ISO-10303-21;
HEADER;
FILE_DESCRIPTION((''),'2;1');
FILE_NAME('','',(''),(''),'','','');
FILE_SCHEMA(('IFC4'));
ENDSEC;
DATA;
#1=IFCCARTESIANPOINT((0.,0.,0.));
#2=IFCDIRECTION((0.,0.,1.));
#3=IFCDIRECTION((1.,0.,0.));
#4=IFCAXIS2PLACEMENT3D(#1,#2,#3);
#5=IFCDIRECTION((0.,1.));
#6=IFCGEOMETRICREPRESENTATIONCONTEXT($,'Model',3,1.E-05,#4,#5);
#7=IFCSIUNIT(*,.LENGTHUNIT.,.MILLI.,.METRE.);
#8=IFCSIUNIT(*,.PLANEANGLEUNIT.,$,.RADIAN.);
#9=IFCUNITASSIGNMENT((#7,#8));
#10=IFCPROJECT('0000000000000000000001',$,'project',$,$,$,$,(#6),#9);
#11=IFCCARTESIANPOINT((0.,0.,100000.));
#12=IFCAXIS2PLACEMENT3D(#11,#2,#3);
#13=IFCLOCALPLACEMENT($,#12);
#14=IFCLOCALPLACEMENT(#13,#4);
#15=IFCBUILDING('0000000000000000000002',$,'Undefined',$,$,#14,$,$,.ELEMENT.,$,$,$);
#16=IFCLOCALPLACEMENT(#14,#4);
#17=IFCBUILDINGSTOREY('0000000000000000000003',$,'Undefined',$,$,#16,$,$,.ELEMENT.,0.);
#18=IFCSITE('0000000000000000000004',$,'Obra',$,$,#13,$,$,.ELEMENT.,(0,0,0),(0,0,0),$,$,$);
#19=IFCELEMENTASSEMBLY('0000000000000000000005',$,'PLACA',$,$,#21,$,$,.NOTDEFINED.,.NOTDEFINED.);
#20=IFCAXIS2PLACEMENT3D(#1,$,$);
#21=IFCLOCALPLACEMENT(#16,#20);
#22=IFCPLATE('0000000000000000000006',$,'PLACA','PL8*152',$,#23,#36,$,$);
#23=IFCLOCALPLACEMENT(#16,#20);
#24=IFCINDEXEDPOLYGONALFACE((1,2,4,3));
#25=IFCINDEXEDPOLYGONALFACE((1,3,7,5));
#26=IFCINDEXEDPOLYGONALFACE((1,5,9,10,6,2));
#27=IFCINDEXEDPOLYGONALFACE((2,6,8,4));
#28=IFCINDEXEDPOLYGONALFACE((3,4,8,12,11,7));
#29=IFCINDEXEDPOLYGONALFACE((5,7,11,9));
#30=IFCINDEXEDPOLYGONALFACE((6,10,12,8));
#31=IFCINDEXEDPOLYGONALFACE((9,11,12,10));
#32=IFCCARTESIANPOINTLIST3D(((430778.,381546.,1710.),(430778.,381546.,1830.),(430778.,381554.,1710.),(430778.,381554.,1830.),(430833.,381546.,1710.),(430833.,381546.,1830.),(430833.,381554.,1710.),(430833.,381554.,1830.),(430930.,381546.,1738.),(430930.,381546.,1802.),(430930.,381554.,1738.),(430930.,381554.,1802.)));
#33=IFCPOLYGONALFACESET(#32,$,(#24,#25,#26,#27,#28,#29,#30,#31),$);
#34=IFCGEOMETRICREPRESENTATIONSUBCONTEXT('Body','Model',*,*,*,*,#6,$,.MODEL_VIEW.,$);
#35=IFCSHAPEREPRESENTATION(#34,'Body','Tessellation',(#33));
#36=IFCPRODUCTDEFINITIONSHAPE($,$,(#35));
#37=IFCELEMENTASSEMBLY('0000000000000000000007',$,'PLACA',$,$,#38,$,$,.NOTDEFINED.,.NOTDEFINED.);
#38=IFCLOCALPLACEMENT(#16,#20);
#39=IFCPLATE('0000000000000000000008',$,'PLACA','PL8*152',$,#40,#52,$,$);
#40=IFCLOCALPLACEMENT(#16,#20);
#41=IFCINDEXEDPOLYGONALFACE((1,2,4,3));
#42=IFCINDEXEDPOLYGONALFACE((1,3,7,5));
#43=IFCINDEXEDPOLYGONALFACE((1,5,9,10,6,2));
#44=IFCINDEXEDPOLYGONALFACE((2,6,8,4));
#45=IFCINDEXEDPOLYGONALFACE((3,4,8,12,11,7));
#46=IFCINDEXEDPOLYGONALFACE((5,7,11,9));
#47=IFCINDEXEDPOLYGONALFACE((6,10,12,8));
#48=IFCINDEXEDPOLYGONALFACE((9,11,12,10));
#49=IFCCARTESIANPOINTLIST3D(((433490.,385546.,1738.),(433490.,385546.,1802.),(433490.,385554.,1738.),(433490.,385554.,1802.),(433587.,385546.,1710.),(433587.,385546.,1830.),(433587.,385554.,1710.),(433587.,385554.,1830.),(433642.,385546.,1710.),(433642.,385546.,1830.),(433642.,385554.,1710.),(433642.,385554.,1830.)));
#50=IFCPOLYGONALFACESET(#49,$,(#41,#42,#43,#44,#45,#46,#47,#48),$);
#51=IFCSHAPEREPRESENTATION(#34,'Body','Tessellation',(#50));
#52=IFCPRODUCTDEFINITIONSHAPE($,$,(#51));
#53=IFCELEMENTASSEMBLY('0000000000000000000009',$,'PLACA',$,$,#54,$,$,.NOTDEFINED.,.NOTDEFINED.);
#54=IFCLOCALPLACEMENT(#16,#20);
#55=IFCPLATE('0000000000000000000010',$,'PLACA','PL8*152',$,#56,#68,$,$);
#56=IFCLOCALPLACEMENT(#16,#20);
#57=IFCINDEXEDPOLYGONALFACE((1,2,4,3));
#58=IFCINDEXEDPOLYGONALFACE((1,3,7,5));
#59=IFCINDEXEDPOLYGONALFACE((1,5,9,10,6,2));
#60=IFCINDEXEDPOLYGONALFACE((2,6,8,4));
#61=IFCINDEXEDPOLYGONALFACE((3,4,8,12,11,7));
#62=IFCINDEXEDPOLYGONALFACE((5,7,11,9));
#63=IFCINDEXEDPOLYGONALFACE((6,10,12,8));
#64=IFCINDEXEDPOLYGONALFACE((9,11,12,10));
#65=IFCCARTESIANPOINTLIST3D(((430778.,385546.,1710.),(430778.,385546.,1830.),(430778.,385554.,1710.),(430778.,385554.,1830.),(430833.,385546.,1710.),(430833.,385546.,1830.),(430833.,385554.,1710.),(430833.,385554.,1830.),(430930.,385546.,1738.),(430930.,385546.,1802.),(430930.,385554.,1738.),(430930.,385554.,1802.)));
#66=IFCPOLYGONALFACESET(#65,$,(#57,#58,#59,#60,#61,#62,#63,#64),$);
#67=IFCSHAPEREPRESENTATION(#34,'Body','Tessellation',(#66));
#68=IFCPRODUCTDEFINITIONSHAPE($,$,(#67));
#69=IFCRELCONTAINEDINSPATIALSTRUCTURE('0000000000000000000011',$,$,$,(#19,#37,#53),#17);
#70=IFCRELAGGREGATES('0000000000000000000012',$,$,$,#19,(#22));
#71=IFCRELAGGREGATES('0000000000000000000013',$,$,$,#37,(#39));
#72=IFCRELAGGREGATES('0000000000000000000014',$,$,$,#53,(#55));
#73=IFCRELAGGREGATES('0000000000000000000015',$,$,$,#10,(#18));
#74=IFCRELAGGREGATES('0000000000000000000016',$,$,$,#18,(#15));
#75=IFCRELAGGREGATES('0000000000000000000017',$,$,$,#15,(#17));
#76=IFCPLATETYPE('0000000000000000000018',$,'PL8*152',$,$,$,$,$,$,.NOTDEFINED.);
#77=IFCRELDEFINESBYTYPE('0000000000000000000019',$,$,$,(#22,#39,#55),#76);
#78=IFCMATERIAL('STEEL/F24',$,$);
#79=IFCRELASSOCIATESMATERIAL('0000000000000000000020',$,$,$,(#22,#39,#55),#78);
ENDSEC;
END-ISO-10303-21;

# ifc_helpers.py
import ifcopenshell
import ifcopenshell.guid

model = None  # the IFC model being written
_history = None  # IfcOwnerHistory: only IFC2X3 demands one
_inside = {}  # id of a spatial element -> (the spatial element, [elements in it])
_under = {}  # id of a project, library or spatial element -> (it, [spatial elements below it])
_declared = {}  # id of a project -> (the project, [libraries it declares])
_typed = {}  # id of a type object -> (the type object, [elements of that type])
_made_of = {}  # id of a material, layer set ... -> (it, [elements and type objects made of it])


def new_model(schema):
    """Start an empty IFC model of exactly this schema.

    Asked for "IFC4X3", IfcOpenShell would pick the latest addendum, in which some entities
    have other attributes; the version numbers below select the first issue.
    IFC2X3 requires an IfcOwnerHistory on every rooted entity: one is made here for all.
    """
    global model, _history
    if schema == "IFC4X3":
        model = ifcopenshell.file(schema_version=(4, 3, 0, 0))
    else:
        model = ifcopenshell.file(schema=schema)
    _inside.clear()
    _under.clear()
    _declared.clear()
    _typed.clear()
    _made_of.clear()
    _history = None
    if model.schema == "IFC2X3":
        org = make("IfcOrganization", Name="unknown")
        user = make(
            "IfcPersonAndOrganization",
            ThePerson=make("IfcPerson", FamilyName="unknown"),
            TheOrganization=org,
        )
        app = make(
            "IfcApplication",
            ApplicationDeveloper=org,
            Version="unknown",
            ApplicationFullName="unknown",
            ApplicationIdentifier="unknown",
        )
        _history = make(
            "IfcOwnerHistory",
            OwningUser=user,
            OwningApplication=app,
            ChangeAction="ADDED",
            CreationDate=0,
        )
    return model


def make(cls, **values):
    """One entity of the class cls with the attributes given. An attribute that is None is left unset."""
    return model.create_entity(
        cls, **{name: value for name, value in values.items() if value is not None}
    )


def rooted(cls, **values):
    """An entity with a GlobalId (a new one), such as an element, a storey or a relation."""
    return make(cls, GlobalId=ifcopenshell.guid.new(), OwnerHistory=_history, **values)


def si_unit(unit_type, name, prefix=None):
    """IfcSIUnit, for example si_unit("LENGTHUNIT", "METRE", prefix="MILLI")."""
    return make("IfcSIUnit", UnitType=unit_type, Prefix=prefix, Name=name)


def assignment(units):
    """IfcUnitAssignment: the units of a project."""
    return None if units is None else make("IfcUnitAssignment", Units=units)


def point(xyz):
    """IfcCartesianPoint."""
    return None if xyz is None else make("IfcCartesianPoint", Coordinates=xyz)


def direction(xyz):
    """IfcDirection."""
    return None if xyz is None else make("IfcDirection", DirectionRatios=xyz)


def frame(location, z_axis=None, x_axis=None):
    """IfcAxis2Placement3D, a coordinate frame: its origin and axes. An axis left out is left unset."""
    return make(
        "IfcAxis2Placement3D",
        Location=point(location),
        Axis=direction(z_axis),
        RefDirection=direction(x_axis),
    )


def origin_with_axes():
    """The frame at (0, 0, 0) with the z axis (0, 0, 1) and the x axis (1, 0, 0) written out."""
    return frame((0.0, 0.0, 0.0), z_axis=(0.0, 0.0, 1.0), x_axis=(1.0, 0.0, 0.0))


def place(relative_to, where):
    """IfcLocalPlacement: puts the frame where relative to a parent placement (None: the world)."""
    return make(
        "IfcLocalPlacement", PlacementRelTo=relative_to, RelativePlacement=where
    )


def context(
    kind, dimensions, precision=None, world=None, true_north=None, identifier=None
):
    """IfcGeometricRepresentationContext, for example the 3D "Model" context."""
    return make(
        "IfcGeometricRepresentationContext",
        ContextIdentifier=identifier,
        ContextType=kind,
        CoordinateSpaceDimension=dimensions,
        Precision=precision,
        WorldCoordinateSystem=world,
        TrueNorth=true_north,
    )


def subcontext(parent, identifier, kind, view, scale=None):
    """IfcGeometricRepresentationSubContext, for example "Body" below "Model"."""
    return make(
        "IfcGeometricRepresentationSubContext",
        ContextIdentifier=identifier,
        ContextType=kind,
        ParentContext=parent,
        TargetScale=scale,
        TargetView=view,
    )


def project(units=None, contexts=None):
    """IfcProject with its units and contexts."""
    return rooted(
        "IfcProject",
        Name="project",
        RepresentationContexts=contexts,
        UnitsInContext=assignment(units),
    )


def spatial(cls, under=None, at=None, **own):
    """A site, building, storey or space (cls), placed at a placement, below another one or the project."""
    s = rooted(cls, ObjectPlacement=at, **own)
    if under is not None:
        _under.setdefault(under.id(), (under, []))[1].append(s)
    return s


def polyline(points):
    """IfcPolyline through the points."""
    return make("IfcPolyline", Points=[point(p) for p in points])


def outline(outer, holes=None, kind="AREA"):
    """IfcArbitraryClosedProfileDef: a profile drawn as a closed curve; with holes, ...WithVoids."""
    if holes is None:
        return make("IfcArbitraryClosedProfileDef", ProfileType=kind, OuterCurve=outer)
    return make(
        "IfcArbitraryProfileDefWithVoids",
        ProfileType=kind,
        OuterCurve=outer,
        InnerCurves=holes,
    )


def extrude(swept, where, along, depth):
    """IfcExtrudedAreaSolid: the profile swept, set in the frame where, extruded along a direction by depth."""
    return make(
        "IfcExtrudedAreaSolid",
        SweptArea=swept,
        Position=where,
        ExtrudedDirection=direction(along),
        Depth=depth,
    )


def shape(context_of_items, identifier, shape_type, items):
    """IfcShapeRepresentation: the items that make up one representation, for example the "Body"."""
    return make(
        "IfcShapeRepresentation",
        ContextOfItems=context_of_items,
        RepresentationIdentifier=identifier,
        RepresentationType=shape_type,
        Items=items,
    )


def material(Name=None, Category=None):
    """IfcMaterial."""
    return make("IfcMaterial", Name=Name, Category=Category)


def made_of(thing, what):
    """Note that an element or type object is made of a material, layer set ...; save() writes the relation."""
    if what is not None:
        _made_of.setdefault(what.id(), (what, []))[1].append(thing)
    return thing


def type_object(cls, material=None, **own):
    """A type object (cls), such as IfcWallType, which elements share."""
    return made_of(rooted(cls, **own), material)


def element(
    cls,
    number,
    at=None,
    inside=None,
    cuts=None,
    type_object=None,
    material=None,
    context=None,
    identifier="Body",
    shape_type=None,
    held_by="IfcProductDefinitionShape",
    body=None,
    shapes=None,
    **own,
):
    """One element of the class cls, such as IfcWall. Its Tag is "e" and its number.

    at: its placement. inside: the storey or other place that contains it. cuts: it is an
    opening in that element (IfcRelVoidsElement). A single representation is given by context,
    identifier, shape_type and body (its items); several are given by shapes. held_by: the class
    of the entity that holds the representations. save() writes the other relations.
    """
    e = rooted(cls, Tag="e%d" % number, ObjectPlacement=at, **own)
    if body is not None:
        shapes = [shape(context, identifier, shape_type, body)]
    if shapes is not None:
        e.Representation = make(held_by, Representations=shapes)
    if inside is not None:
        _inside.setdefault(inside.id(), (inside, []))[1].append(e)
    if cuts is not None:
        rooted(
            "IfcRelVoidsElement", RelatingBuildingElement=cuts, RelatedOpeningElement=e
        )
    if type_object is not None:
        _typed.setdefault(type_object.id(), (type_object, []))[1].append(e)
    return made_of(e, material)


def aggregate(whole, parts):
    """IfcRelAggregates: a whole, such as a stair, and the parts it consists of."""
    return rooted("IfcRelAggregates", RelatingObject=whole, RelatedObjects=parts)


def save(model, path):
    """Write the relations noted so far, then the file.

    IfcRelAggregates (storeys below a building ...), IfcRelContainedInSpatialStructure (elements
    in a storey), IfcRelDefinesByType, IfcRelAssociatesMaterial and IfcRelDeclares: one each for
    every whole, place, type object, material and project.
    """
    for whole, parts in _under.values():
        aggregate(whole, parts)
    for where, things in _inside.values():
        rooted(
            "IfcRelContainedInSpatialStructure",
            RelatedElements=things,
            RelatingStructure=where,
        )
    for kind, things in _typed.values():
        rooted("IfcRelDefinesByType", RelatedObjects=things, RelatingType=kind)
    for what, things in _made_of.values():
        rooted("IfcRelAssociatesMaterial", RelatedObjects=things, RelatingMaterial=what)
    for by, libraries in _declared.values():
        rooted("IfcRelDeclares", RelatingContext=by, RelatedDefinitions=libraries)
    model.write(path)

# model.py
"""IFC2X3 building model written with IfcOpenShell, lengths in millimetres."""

from ifc_helpers import new_model, si_unit, direction, frame, origin_with_axes, place, context, subcontext, project, spatial, polyline, outline, extrude, material, type_object, element, aggregate, save


model = new_model("IFC2X3")

# Units and contexts
model_context = context("Model", 3, precision=1e-05, world=origin_with_axes(), true_north=direction((0.0, 1.0)))
body_context = subcontext(model_context, "Body", "Model", "MODEL_VIEW")
ifc_project = project(units=[si_unit("LENGTHUNIT", "METRE", prefix="MILLI"), si_unit("PLANEANGLEUNIT", "RADIAN")], contexts=[model_context])

# Site, building, storey
site_placement = place(None, frame((0.0, 0.0, 100000.0), z_axis=(0.0, 0.0, 1.0), x_axis=(1.0, 0.0, 0.0)))
site = spatial("IfcSite", under=ifc_project, at=site_placement, Name="Obra", CompositionType="ELEMENT", RefLatitude=(0, 0, 0), RefLongitude=(0, 0, 0))
building_placement = place(site_placement, origin_with_axes())
building = spatial("IfcBuilding", under=site, at=building_placement, Name="Undefined", CompositionType="ELEMENT")
storey_placement = place(building_placement, origin_with_axes())
storey = spatial("IfcBuildingStorey", under=building, at=storey_placement, Name="Undefined", CompositionType="ELEMENT", Elevation=0.0)

# Shared definitions
ifc_material_1 = material(Name="STEEL/F24")

# Element assemblies, plates
plate_type_1 = type_object("IfcPlateType", Name="PL8*152", PredefinedType="NOTDEFINED")
assembly_1_placement = place(storey_placement, origin_with_axes())
assembly_1 = element("IfcElementAssembly", 1, at=assembly_1_placement, inside=storey, Name="PLACA", AssemblyPlace="NOTDEFINED", PredefinedType="NOTDEFINED")
plate_1_placement = place(assembly_1_placement, frame((430833.0, 381550.0, 1830.0), z_axis=(0.0, -1.0, 0.0), x_axis=(-1.0, 0.0, 0.0)))
plate_1 = element("IfcPlate", 2, at=plate_1_placement, type_object=plate_type_1, material=ifc_material_1, Name="PLACA", Description="PL8*152", context=body_context, shape_type="SweptSolid", body=[
    extrude(outline(polyline([(0.0, 0.0), (55.0, 0.0), (55.0, 120.0), (0.0, 120.0), (-97.0, 92.0), (-97.0, 28.0), (0.0, 0.0)])), frame((0.0, 0.0, -4.0), z_axis=(0.0, 0.0, 1.0), x_axis=(1.0, 0.0, 0.0)), (0.0, 0.0, 1.0), 8.0),
])
aggregate(assembly_1, [plate_1])
assembly_2_placement = place(storey_placement, origin_with_axes())
assembly_2 = element("IfcElementAssembly", 3, at=assembly_2_placement, inside=storey, Name="PLACA", AssemblyPlace="NOTDEFINED", PredefinedType="NOTDEFINED")
plate_2_placement = place(assembly_2_placement, frame((433587.0, 385550.0, 1830.0), z_axis=(0.0, 1.0, 0.0), x_axis=(1.0, 0.0, 0.0)))
plate_2 = element("IfcPlate", 4, at=plate_2_placement, type_object=plate_type_1, material=ifc_material_1, Name="PLACA", Description="PL8*152", context=body_context, shape_type="SweptSolid", body=[
    extrude(outline(polyline([(0.0, 0.0), (55.0, 0.0), (55.0, 120.0), (0.0, 120.0), (-97.0, 92.0), (-97.0, 28.0), (0.0, 0.0)])), frame((0.0, 0.0, -4.0), z_axis=(0.0, 0.0, 1.0), x_axis=(1.0, 0.0, 0.0)), (0.0, 0.0, 1.0), 8.0),
])
aggregate(assembly_2, [plate_2])
assembly_3_placement = place(storey_placement, origin_with_axes())
assembly_3 = element("IfcElementAssembly", 5, at=assembly_3_placement, inside=storey, Name="PLACA", AssemblyPlace="NOTDEFINED", PredefinedType="NOTDEFINED")
plate_3_placement = place(assembly_3_placement, frame((430833.0, 385550.0, 1830.0), z_axis=(0.0, -1.0, 0.0), x_axis=(-1.0, 0.0, 0.0)))
plate_3 = element("IfcPlate", 6, at=plate_3_placement, type_object=plate_type_1, material=ifc_material_1, Name="PLACA", Description="PL8*152", context=body_context, shape_type="SweptSolid", body=[
    extrude(outline(polyline([(0.0, 0.0), (55.0, 0.0), (55.0, 120.0), (0.0, 120.0), (-97.0, 92.0), (-97.0, 28.0), (0.0, 0.0)])), frame((0.0, 0.0, -4.0), z_axis=(0.0, 0.0, 1.0), x_axis=(1.0, 0.0, 0.0)), (0.0, 0.0, 1.0), 8.0),
])
aggregate(assembly_3, [plate_3])

save(model, "model.ifc")
